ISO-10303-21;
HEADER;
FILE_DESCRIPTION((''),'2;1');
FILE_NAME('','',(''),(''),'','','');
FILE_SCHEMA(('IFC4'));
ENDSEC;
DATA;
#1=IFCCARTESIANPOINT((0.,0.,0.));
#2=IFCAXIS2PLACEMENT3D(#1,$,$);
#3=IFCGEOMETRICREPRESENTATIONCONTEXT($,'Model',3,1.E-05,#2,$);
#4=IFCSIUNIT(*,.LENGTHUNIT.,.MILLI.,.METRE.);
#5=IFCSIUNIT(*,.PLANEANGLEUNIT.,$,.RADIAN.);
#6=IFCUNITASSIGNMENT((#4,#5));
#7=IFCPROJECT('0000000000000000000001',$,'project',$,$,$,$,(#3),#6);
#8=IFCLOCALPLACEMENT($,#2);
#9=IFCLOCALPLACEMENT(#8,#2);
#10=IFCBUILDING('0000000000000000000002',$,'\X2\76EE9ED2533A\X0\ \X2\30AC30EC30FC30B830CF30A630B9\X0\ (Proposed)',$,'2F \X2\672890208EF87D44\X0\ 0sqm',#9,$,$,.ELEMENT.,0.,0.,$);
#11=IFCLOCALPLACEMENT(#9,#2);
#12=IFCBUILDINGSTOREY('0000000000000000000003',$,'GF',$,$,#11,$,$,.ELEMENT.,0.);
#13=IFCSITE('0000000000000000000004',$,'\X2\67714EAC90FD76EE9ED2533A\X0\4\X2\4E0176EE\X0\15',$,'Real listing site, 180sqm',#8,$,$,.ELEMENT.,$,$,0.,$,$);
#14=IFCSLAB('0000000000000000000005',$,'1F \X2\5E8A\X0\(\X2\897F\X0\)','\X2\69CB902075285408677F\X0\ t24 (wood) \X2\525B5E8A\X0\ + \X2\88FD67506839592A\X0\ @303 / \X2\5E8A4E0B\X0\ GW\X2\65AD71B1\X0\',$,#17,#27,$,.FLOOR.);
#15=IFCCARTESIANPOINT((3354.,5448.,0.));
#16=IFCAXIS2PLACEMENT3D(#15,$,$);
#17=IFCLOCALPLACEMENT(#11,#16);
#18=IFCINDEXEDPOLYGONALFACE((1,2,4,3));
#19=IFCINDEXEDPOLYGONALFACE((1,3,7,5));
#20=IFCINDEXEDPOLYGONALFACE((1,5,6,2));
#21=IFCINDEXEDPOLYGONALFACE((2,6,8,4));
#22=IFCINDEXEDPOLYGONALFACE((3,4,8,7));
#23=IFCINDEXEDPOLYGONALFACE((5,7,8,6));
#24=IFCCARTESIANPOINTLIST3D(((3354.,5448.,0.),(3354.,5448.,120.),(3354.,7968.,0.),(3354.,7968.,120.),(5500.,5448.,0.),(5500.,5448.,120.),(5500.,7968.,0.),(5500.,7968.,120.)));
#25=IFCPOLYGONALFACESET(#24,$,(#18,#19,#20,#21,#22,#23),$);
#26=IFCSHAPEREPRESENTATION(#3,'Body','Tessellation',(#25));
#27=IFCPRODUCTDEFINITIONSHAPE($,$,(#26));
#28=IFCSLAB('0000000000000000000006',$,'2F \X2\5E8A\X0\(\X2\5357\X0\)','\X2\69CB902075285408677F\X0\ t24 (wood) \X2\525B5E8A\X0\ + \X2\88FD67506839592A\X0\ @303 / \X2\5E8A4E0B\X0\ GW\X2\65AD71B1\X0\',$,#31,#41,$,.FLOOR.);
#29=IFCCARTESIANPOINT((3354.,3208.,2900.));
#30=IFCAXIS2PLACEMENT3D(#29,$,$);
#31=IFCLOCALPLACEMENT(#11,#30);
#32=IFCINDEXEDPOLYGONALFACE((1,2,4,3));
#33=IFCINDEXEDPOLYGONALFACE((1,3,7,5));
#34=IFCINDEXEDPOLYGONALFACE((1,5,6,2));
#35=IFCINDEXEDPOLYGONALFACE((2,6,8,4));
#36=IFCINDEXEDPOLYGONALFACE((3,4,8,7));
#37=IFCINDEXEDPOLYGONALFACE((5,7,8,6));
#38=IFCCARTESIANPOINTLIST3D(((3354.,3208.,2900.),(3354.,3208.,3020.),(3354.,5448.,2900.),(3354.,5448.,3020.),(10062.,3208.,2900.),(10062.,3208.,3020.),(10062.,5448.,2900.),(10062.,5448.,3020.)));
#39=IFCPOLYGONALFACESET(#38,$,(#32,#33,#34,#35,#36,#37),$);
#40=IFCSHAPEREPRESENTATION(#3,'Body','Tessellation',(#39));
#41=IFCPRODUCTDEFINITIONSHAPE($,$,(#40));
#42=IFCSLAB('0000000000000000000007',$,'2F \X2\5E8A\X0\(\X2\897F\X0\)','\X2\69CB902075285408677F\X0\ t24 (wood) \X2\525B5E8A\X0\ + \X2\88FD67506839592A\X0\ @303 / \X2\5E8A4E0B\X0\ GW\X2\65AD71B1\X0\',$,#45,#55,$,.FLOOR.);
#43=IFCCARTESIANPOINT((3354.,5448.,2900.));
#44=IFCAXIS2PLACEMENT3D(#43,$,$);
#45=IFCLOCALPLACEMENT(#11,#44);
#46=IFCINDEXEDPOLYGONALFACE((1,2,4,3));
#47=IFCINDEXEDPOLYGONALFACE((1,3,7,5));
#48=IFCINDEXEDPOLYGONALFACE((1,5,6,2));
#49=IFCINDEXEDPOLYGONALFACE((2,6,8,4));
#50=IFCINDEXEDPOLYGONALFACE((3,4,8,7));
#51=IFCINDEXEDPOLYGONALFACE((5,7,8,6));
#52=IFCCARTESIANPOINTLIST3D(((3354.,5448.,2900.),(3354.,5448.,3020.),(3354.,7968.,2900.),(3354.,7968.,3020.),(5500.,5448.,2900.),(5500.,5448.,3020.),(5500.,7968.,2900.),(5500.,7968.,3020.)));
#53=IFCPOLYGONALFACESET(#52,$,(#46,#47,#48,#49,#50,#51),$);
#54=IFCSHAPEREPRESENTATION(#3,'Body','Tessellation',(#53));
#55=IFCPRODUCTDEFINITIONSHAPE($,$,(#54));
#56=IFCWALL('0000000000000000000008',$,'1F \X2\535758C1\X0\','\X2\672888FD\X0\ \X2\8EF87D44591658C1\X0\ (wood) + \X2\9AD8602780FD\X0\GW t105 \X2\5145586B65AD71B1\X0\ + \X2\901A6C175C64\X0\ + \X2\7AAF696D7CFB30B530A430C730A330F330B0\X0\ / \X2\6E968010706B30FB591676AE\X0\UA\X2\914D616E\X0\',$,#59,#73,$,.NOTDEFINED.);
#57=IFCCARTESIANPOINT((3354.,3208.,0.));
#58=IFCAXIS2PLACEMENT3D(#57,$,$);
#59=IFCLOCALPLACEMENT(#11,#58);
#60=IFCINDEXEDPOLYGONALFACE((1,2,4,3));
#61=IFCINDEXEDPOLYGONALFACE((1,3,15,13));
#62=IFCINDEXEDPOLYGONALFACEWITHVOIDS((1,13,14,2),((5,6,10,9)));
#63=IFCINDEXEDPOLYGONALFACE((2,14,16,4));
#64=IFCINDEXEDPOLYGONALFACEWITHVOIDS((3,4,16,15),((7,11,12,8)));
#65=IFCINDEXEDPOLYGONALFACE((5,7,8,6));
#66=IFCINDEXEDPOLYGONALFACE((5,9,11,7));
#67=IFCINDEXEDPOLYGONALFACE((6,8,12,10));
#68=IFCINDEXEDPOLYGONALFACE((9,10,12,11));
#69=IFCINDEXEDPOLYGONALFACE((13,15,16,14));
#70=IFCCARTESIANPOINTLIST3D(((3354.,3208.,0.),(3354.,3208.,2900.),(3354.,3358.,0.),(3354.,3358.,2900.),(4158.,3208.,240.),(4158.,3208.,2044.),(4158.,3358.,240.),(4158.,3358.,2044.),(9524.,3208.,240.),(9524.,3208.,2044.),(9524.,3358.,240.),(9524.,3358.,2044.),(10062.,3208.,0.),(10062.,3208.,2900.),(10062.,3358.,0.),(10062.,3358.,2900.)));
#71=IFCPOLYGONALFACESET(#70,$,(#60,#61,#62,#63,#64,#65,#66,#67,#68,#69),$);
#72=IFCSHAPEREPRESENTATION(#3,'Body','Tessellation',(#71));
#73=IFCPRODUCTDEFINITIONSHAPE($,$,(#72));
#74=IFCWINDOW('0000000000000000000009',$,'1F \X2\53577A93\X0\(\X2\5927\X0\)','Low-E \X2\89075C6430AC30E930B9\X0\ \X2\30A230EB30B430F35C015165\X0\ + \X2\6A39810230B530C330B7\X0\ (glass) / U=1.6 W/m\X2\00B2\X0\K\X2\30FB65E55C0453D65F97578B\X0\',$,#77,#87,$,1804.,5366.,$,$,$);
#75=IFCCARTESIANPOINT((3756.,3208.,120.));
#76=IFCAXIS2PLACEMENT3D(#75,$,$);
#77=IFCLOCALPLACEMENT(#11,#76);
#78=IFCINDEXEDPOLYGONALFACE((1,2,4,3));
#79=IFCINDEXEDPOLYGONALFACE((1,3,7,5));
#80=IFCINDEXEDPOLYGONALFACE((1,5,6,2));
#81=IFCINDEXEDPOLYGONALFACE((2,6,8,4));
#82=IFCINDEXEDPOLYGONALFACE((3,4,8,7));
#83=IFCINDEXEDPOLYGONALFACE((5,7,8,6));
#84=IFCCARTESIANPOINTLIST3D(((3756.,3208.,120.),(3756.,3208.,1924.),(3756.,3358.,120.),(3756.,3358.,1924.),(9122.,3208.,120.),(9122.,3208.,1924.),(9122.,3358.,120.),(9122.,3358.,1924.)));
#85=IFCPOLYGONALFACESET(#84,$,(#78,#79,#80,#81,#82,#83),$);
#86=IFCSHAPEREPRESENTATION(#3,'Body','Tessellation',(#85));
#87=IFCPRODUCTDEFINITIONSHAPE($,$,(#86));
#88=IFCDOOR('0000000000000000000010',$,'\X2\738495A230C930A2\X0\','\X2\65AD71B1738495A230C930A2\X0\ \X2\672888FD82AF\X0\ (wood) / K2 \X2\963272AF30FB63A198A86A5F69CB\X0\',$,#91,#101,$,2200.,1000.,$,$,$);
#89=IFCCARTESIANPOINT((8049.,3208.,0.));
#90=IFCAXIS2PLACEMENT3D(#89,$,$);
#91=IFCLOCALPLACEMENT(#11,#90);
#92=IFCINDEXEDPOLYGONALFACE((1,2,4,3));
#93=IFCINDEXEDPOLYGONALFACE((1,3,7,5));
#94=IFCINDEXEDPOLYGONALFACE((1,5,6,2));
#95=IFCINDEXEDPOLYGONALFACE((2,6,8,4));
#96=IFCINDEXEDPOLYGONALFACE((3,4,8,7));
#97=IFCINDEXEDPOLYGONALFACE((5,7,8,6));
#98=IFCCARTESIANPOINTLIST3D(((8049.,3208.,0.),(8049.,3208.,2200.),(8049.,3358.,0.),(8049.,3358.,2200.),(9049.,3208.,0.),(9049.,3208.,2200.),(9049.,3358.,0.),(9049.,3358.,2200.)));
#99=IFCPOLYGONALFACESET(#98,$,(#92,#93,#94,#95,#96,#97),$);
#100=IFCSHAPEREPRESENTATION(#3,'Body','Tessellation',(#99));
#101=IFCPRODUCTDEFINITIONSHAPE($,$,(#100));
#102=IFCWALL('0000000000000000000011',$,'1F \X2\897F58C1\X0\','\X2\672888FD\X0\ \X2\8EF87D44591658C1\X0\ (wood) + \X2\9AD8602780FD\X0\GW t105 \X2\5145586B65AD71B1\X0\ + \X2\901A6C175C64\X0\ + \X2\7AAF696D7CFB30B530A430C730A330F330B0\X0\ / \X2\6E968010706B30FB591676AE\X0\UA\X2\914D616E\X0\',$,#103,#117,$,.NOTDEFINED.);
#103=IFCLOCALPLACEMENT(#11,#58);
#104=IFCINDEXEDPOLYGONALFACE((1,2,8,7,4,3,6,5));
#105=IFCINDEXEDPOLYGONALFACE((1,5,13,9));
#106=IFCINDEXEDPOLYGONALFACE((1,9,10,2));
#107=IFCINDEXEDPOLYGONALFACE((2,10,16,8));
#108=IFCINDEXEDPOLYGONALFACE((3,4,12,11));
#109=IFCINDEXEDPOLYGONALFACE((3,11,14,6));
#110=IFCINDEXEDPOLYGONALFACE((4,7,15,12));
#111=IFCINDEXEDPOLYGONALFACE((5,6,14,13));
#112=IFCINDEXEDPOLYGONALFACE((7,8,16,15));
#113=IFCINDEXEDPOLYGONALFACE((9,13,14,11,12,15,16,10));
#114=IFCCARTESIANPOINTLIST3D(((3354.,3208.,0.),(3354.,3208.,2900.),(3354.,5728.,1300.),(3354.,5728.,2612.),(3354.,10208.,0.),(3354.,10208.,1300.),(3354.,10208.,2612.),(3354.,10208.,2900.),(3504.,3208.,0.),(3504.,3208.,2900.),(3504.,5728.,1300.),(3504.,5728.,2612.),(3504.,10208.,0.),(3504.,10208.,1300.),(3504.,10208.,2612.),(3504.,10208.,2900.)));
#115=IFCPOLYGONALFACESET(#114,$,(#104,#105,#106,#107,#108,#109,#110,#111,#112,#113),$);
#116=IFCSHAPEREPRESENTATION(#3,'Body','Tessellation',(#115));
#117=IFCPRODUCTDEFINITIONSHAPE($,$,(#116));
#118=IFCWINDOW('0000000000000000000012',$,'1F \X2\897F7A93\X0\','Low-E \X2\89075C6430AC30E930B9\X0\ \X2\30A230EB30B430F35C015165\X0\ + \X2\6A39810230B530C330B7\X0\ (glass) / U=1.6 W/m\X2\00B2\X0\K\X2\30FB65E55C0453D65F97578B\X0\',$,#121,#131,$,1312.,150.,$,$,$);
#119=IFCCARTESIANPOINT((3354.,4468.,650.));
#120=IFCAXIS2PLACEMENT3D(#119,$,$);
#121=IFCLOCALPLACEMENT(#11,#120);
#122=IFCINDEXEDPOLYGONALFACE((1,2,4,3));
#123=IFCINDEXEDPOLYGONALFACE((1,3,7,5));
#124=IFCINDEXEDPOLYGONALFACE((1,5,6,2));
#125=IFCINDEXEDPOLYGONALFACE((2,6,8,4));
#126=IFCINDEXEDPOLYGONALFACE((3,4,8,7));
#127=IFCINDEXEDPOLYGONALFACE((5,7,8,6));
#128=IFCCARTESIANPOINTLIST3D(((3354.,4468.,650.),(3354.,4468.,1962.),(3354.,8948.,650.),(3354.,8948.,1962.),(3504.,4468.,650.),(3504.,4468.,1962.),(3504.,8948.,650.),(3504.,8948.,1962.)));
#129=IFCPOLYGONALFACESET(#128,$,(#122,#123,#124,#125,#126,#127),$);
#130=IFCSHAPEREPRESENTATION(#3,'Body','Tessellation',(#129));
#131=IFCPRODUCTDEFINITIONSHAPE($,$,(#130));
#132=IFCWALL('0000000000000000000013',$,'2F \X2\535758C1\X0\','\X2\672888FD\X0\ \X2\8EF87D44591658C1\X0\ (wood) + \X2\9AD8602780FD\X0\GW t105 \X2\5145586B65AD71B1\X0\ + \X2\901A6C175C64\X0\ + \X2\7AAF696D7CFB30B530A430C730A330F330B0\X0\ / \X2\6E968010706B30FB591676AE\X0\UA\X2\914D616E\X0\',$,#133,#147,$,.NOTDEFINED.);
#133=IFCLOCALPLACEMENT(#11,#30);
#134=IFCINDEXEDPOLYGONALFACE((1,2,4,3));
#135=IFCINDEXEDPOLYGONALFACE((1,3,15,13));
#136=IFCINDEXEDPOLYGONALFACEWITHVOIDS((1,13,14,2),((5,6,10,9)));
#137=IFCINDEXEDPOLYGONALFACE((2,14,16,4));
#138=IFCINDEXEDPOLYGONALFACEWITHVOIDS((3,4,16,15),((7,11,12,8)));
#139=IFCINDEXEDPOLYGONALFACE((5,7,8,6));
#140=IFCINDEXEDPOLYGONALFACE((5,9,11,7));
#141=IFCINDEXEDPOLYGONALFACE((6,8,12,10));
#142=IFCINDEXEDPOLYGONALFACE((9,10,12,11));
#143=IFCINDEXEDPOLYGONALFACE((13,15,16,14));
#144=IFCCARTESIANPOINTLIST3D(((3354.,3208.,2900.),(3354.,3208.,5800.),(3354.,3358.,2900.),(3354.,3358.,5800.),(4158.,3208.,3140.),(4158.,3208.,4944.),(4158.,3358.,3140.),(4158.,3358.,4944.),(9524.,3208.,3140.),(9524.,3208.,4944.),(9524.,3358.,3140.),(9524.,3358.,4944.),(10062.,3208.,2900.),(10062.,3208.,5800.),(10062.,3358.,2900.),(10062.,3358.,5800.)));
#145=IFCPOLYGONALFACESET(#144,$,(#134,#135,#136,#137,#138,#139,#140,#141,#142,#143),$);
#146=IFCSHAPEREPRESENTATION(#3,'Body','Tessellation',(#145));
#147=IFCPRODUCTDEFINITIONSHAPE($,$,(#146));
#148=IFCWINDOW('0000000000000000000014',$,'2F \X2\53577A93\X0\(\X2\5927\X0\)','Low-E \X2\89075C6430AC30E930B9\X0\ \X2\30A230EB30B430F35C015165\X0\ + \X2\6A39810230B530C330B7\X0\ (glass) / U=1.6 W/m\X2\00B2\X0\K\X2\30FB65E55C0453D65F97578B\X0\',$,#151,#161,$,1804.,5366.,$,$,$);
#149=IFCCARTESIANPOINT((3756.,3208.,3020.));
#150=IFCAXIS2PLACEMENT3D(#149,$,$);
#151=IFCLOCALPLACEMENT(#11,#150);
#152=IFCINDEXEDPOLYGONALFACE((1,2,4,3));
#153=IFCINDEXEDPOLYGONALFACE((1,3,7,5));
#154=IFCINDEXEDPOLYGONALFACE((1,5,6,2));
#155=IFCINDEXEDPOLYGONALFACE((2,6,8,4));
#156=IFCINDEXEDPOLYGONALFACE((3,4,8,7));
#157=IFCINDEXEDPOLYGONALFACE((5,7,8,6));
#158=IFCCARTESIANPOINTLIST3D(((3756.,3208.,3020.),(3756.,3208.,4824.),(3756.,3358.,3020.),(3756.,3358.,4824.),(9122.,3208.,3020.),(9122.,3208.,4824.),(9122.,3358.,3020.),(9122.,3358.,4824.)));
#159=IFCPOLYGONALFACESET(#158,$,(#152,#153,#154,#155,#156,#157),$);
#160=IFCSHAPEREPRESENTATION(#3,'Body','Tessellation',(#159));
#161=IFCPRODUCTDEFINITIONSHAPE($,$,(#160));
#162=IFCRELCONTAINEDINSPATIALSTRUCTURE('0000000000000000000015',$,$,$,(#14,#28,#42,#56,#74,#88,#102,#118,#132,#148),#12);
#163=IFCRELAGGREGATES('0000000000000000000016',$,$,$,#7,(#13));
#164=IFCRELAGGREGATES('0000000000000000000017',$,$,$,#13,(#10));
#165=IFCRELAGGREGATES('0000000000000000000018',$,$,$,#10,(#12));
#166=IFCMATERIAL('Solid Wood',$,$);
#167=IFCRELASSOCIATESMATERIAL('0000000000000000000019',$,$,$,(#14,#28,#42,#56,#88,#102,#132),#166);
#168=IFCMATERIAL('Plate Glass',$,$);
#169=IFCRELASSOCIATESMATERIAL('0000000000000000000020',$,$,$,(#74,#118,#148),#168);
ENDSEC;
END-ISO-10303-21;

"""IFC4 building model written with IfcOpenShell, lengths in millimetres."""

from ifc_helpers import new_model, si_unit, frame, frame_2d, origin, place, context, project, spatial, rectangle, extrude, material, element, fill, save


model = new_model("IFC4")

# Units and contexts
model_context = context("Model", 3, precision=1e-05, world=origin())
ifc_project = project(units=[si_unit("LENGTHUNIT", "METRE", prefix="MILLI"), si_unit("PLANEANGLEUNIT", "RADIAN")], contexts=[model_context])

# Site, building, storey
site_placement = place(None, origin())
site = spatial("IfcSite", under=ifc_project, at=site_placement, Name="東京都目黒区4丁目15", ObjectType="Real listing site, 180sqm", CompositionType="ELEMENT", RefElevation=0.0)
building_placement = place(site_placement, origin())
building = spatial("IfcBuilding", under=site, at=building_placement, Name="目黒区 ガレージハウス (Proposed)", ObjectType="2F 木造軸組 0sqm", CompositionType="ELEMENT", ElevationOfRefHeight=0.0, ElevationOfTerrain=0.0)
storey_placement = place(building_placement, origin())
storey = spatial("IfcBuildingStorey", under=building, at=storey_placement, Name="GF", CompositionType="ELEMENT", Elevation=0.0)

# Slabs
ifc_material_1 = material(Name="Solid Wood")
slab_1_placement = place(storey_placement, frame((3354.0, 5448.0, 0.0)))
element("IfcSlab", 1, at=slab_1_placement, inside=storey, material=ifc_material_1, Name="1F 床(西)", Description="構造用合板 t24 (wood) 剛床 + 製材根太 @303 / 床下 GW断熱", PredefinedType="FLOOR", context=model_context, shape_type="SweptSolid", body=[
    extrude(rectangle(XDim=2146.0, YDim=2520.0, at=frame_2d((1073.0, 1260.0))), frame((3354.0, 5448.0, 0.0)), (0.0, 0.0, 1.0), 120.0),
])
slab_2_placement = place(storey_placement, frame((3354.0, 3208.0, 2900.0)))
element("IfcSlab", 2, at=slab_2_placement, inside=storey, material=ifc_material_1, Name="2F 床(南)", Description="構造用合板 t24 (wood) 剛床 + 製材根太 @303 / 床下 GW断熱", PredefinedType="FLOOR", context=model_context, shape_type="SweptSolid", body=[
    extrude(rectangle(XDim=6708.0, YDim=2240.0, at=frame_2d((3354.0, 1120.0))), frame((3354.0, 3208.0, 2900.0)), (0.0, 0.0, 1.0), 120.0),
])
slab_3_placement = place(storey_placement, frame((3354.0, 5448.0, 2900.0)))
element("IfcSlab", 3, at=slab_3_placement, inside=storey, material=ifc_material_1, Name="2F 床(西)", Description="構造用合板 t24 (wood) 剛床 + 製材根太 @303 / 床下 GW断熱", PredefinedType="FLOOR", context=model_context, shape_type="SweptSolid", body=[
    extrude(rectangle(XDim=2146.0, YDim=2520.0, at=frame_2d((1073.0, 1260.0))), frame((3354.0, 5448.0, 2900.0)), (0.0, 0.0, 1.0), 120.0),
])

# Wall, openings, window, door
wall_1_placement = place(storey_placement, frame((3354.0, 3208.0, 0.0)))
wall_1 = element("IfcWall", 4, at=wall_1_placement, inside=storey, material=ifc_material_1, Name="1F 南壁", Description="木製 軸組外壁 (wood) + 高性能GW t105 充填断熱 + 通気層 + 窯業系サイディング / 準耐火・外皮UA配慮", PredefinedType="NOTDEFINED", context=model_context, shape_type="SweptSolid", body=[
    extrude(rectangle(XDim=6708.0, YDim=150.0, at=frame_2d((3354.0, 75.0))), frame((3354.0, 3208.0, 0.0)), (0.0, 0.0, 1.0), 2900.0),
])
opening_1_placement = place(storey_placement, frame((3756.0, 3208.0, 120.0)))
opening_1 = element("IfcOpeningElement", 5, at=opening_1_placement, cuts=wall_1, PredefinedType="NOTDEFINED", context=model_context, shape_type="SweptSolid", body=[
    extrude(rectangle(XDim=5366.0, YDim=150.0, at=frame_2d((2683.0, 75.0))), frame((3756.0, 3208.0, 120.0)), (0.0, 0.0, 1.0), 1804.0),
])
opening_2_placement = place(storey_placement, frame((8049.0, 3208.0, 0.0)))
opening_2 = element("IfcOpeningElement", 6, at=opening_2_placement, cuts=wall_1, PredefinedType="NOTDEFINED", context=model_context, shape_type="SweptSolid", body=[
    extrude(rectangle(XDim=1000.0, YDim=150.0, at=frame_2d((500.0, 75.0))), frame((8049.0, 3208.0, 0.0)), (0.0, 0.0, 1.0), 2200.0),
])
ifc_material_2 = material(Name="Plate Glass")
window_1_placement = place(storey_placement, frame((3756.0, 3208.0, 120.0)))
window_1 = element("IfcWindow", 7, at=window_1_placement, inside=storey, material=ifc_material_2, Name="1F 南窓(大)", Description="Low-E 複層ガラス アルゴン封入 + 樹脂サッシ (glass) / U=1.6 W/m²K・日射取得型", OverallHeight=1804.0, OverallWidth=5366.0, context=model_context, shape_type="SweptSolid", body=[
    extrude(rectangle(XDim=5366.0, YDim=150.0, at=frame_2d((2683.0, 75.0))), frame((3756.0, 3208.0, 120.0)), (0.0, 0.0, 1.0), 1804.0),
])
fill(opening_1, window_1)
door_placement = place(storey_placement, frame((8049.0, 3208.0, 0.0)))
door = element("IfcDoor", 8, at=door_placement, inside=storey, material=ifc_material_1, Name="玄関ドア", Description="断熱玄関ドア 木製芯 (wood) / K2 防犯・採風機構", OverallHeight=2200.0, OverallWidth=1000.0, context=model_context, shape_type="SweptSolid", body=[
    extrude(rectangle(XDim=1000.0, YDim=150.0, at=frame_2d((500.0, 75.0))), frame((8049.0, 3208.0, 0.0)), (0.0, 0.0, 1.0), 2200.0),
])
fill(opening_2, door)

# Walls, openings, windows
wall_2_placement = place(storey_placement, frame((3354.0, 3208.0, 0.0)))
wall_2 = element("IfcWall", 9, at=wall_2_placement, inside=storey, material=ifc_material_1, Name="1F 西壁", Description="木製 軸組外壁 (wood) + 高性能GW t105 充填断熱 + 通気層 + 窯業系サイディング / 準耐火・外皮UA配慮", PredefinedType="NOTDEFINED", context=model_context, shape_type="SweptSolid", body=[
    extrude(rectangle(XDim=150.0, YDim=7000.0, at=frame_2d((75.0, 3500.0))), frame((3354.0, 3208.0, 0.0)), (0.0, 0.0, 1.0), 2900.0),
])
opening_3_placement = place(storey_placement, frame((3354.0, 4468.0, 650.0)))
opening_3 = element("IfcOpeningElement", 10, at=opening_3_placement, cuts=wall_2, PredefinedType="NOTDEFINED", context=model_context, shape_type="SweptSolid", body=[
    extrude(rectangle(XDim=150.0, YDim=4480.0, at=frame_2d((75.0, 2240.0))), frame((3354.0, 4468.0, 650.0)), (0.0, 0.0, 1.0), 1312.0),
])
window_2_placement = place(storey_placement, frame((3354.0, 4468.0, 650.0)))
window_2 = element("IfcWindow", 11, at=window_2_placement, inside=storey, material=ifc_material_2, Name="1F 西窓", Description="Low-E 複層ガラス アルゴン封入 + 樹脂サッシ (glass) / U=1.6 W/m²K・日射取得型", OverallHeight=1312.0, OverallWidth=150.0, context=model_context, shape_type="SweptSolid", body=[
    extrude(rectangle(XDim=150.0, YDim=4480.0, at=frame_2d((75.0, 2240.0))), frame((3354.0, 4468.0, 650.0)), (0.0, 0.0, 1.0), 1312.0),
])
fill(opening_3, window_2)
wall_3_placement = place(storey_placement, frame((3354.0, 3208.0, 2900.0)))
wall_3 = element("IfcWall", 12, at=wall_3_placement, inside=storey, material=ifc_material_1, Name="2F 南壁", Description="木製 軸組外壁 (wood) + 高性能GW t105 充填断熱 + 通気層 + 窯業系サイディング / 準耐火・外皮UA配慮", PredefinedType="NOTDEFINED", context=model_context, shape_type="SweptSolid", body=[
    extrude(rectangle(XDim=6708.0, YDim=150.0, at=frame_2d((3354.0, 75.0))), frame((3354.0, 3208.0, 2900.0)), (0.0, 0.0, 1.0), 2900.0),
])
opening_4_placement = place(storey_placement, frame((3756.0, 3208.0, 3020.0)))
opening_4 = element("IfcOpeningElement", 13, at=opening_4_placement, cuts=wall_3, PredefinedType="NOTDEFINED", context=model_context, shape_type="SweptSolid", body=[
    extrude(rectangle(XDim=5366.0, YDim=150.0, at=frame_2d((2683.0, 75.0))), frame((3756.0, 3208.0, 3020.0)), (0.0, 0.0, 1.0), 1804.0),
])
window_3_placement = place(storey_placement, frame((3756.0, 3208.0, 3020.0)))
window_3 = element("IfcWindow", 14, at=window_3_placement, inside=storey, material=ifc_material_2, Name="2F 南窓(大)", Description="Low-E 複層ガラス アルゴン封入 + 樹脂サッシ (glass) / U=1.6 W/m²K・日射取得型", OverallHeight=1804.0, OverallWidth=5366.0, context=model_context, shape_type="SweptSolid", body=[
    extrude(rectangle(XDim=5366.0, YDim=150.0, at=frame_2d((2683.0, 75.0))), frame((3756.0, 3208.0, 3020.0)), (0.0, 0.0, 1.0), 1804.0),
])
fill(opening_4, window_3)

save(model, "model.ifc")
